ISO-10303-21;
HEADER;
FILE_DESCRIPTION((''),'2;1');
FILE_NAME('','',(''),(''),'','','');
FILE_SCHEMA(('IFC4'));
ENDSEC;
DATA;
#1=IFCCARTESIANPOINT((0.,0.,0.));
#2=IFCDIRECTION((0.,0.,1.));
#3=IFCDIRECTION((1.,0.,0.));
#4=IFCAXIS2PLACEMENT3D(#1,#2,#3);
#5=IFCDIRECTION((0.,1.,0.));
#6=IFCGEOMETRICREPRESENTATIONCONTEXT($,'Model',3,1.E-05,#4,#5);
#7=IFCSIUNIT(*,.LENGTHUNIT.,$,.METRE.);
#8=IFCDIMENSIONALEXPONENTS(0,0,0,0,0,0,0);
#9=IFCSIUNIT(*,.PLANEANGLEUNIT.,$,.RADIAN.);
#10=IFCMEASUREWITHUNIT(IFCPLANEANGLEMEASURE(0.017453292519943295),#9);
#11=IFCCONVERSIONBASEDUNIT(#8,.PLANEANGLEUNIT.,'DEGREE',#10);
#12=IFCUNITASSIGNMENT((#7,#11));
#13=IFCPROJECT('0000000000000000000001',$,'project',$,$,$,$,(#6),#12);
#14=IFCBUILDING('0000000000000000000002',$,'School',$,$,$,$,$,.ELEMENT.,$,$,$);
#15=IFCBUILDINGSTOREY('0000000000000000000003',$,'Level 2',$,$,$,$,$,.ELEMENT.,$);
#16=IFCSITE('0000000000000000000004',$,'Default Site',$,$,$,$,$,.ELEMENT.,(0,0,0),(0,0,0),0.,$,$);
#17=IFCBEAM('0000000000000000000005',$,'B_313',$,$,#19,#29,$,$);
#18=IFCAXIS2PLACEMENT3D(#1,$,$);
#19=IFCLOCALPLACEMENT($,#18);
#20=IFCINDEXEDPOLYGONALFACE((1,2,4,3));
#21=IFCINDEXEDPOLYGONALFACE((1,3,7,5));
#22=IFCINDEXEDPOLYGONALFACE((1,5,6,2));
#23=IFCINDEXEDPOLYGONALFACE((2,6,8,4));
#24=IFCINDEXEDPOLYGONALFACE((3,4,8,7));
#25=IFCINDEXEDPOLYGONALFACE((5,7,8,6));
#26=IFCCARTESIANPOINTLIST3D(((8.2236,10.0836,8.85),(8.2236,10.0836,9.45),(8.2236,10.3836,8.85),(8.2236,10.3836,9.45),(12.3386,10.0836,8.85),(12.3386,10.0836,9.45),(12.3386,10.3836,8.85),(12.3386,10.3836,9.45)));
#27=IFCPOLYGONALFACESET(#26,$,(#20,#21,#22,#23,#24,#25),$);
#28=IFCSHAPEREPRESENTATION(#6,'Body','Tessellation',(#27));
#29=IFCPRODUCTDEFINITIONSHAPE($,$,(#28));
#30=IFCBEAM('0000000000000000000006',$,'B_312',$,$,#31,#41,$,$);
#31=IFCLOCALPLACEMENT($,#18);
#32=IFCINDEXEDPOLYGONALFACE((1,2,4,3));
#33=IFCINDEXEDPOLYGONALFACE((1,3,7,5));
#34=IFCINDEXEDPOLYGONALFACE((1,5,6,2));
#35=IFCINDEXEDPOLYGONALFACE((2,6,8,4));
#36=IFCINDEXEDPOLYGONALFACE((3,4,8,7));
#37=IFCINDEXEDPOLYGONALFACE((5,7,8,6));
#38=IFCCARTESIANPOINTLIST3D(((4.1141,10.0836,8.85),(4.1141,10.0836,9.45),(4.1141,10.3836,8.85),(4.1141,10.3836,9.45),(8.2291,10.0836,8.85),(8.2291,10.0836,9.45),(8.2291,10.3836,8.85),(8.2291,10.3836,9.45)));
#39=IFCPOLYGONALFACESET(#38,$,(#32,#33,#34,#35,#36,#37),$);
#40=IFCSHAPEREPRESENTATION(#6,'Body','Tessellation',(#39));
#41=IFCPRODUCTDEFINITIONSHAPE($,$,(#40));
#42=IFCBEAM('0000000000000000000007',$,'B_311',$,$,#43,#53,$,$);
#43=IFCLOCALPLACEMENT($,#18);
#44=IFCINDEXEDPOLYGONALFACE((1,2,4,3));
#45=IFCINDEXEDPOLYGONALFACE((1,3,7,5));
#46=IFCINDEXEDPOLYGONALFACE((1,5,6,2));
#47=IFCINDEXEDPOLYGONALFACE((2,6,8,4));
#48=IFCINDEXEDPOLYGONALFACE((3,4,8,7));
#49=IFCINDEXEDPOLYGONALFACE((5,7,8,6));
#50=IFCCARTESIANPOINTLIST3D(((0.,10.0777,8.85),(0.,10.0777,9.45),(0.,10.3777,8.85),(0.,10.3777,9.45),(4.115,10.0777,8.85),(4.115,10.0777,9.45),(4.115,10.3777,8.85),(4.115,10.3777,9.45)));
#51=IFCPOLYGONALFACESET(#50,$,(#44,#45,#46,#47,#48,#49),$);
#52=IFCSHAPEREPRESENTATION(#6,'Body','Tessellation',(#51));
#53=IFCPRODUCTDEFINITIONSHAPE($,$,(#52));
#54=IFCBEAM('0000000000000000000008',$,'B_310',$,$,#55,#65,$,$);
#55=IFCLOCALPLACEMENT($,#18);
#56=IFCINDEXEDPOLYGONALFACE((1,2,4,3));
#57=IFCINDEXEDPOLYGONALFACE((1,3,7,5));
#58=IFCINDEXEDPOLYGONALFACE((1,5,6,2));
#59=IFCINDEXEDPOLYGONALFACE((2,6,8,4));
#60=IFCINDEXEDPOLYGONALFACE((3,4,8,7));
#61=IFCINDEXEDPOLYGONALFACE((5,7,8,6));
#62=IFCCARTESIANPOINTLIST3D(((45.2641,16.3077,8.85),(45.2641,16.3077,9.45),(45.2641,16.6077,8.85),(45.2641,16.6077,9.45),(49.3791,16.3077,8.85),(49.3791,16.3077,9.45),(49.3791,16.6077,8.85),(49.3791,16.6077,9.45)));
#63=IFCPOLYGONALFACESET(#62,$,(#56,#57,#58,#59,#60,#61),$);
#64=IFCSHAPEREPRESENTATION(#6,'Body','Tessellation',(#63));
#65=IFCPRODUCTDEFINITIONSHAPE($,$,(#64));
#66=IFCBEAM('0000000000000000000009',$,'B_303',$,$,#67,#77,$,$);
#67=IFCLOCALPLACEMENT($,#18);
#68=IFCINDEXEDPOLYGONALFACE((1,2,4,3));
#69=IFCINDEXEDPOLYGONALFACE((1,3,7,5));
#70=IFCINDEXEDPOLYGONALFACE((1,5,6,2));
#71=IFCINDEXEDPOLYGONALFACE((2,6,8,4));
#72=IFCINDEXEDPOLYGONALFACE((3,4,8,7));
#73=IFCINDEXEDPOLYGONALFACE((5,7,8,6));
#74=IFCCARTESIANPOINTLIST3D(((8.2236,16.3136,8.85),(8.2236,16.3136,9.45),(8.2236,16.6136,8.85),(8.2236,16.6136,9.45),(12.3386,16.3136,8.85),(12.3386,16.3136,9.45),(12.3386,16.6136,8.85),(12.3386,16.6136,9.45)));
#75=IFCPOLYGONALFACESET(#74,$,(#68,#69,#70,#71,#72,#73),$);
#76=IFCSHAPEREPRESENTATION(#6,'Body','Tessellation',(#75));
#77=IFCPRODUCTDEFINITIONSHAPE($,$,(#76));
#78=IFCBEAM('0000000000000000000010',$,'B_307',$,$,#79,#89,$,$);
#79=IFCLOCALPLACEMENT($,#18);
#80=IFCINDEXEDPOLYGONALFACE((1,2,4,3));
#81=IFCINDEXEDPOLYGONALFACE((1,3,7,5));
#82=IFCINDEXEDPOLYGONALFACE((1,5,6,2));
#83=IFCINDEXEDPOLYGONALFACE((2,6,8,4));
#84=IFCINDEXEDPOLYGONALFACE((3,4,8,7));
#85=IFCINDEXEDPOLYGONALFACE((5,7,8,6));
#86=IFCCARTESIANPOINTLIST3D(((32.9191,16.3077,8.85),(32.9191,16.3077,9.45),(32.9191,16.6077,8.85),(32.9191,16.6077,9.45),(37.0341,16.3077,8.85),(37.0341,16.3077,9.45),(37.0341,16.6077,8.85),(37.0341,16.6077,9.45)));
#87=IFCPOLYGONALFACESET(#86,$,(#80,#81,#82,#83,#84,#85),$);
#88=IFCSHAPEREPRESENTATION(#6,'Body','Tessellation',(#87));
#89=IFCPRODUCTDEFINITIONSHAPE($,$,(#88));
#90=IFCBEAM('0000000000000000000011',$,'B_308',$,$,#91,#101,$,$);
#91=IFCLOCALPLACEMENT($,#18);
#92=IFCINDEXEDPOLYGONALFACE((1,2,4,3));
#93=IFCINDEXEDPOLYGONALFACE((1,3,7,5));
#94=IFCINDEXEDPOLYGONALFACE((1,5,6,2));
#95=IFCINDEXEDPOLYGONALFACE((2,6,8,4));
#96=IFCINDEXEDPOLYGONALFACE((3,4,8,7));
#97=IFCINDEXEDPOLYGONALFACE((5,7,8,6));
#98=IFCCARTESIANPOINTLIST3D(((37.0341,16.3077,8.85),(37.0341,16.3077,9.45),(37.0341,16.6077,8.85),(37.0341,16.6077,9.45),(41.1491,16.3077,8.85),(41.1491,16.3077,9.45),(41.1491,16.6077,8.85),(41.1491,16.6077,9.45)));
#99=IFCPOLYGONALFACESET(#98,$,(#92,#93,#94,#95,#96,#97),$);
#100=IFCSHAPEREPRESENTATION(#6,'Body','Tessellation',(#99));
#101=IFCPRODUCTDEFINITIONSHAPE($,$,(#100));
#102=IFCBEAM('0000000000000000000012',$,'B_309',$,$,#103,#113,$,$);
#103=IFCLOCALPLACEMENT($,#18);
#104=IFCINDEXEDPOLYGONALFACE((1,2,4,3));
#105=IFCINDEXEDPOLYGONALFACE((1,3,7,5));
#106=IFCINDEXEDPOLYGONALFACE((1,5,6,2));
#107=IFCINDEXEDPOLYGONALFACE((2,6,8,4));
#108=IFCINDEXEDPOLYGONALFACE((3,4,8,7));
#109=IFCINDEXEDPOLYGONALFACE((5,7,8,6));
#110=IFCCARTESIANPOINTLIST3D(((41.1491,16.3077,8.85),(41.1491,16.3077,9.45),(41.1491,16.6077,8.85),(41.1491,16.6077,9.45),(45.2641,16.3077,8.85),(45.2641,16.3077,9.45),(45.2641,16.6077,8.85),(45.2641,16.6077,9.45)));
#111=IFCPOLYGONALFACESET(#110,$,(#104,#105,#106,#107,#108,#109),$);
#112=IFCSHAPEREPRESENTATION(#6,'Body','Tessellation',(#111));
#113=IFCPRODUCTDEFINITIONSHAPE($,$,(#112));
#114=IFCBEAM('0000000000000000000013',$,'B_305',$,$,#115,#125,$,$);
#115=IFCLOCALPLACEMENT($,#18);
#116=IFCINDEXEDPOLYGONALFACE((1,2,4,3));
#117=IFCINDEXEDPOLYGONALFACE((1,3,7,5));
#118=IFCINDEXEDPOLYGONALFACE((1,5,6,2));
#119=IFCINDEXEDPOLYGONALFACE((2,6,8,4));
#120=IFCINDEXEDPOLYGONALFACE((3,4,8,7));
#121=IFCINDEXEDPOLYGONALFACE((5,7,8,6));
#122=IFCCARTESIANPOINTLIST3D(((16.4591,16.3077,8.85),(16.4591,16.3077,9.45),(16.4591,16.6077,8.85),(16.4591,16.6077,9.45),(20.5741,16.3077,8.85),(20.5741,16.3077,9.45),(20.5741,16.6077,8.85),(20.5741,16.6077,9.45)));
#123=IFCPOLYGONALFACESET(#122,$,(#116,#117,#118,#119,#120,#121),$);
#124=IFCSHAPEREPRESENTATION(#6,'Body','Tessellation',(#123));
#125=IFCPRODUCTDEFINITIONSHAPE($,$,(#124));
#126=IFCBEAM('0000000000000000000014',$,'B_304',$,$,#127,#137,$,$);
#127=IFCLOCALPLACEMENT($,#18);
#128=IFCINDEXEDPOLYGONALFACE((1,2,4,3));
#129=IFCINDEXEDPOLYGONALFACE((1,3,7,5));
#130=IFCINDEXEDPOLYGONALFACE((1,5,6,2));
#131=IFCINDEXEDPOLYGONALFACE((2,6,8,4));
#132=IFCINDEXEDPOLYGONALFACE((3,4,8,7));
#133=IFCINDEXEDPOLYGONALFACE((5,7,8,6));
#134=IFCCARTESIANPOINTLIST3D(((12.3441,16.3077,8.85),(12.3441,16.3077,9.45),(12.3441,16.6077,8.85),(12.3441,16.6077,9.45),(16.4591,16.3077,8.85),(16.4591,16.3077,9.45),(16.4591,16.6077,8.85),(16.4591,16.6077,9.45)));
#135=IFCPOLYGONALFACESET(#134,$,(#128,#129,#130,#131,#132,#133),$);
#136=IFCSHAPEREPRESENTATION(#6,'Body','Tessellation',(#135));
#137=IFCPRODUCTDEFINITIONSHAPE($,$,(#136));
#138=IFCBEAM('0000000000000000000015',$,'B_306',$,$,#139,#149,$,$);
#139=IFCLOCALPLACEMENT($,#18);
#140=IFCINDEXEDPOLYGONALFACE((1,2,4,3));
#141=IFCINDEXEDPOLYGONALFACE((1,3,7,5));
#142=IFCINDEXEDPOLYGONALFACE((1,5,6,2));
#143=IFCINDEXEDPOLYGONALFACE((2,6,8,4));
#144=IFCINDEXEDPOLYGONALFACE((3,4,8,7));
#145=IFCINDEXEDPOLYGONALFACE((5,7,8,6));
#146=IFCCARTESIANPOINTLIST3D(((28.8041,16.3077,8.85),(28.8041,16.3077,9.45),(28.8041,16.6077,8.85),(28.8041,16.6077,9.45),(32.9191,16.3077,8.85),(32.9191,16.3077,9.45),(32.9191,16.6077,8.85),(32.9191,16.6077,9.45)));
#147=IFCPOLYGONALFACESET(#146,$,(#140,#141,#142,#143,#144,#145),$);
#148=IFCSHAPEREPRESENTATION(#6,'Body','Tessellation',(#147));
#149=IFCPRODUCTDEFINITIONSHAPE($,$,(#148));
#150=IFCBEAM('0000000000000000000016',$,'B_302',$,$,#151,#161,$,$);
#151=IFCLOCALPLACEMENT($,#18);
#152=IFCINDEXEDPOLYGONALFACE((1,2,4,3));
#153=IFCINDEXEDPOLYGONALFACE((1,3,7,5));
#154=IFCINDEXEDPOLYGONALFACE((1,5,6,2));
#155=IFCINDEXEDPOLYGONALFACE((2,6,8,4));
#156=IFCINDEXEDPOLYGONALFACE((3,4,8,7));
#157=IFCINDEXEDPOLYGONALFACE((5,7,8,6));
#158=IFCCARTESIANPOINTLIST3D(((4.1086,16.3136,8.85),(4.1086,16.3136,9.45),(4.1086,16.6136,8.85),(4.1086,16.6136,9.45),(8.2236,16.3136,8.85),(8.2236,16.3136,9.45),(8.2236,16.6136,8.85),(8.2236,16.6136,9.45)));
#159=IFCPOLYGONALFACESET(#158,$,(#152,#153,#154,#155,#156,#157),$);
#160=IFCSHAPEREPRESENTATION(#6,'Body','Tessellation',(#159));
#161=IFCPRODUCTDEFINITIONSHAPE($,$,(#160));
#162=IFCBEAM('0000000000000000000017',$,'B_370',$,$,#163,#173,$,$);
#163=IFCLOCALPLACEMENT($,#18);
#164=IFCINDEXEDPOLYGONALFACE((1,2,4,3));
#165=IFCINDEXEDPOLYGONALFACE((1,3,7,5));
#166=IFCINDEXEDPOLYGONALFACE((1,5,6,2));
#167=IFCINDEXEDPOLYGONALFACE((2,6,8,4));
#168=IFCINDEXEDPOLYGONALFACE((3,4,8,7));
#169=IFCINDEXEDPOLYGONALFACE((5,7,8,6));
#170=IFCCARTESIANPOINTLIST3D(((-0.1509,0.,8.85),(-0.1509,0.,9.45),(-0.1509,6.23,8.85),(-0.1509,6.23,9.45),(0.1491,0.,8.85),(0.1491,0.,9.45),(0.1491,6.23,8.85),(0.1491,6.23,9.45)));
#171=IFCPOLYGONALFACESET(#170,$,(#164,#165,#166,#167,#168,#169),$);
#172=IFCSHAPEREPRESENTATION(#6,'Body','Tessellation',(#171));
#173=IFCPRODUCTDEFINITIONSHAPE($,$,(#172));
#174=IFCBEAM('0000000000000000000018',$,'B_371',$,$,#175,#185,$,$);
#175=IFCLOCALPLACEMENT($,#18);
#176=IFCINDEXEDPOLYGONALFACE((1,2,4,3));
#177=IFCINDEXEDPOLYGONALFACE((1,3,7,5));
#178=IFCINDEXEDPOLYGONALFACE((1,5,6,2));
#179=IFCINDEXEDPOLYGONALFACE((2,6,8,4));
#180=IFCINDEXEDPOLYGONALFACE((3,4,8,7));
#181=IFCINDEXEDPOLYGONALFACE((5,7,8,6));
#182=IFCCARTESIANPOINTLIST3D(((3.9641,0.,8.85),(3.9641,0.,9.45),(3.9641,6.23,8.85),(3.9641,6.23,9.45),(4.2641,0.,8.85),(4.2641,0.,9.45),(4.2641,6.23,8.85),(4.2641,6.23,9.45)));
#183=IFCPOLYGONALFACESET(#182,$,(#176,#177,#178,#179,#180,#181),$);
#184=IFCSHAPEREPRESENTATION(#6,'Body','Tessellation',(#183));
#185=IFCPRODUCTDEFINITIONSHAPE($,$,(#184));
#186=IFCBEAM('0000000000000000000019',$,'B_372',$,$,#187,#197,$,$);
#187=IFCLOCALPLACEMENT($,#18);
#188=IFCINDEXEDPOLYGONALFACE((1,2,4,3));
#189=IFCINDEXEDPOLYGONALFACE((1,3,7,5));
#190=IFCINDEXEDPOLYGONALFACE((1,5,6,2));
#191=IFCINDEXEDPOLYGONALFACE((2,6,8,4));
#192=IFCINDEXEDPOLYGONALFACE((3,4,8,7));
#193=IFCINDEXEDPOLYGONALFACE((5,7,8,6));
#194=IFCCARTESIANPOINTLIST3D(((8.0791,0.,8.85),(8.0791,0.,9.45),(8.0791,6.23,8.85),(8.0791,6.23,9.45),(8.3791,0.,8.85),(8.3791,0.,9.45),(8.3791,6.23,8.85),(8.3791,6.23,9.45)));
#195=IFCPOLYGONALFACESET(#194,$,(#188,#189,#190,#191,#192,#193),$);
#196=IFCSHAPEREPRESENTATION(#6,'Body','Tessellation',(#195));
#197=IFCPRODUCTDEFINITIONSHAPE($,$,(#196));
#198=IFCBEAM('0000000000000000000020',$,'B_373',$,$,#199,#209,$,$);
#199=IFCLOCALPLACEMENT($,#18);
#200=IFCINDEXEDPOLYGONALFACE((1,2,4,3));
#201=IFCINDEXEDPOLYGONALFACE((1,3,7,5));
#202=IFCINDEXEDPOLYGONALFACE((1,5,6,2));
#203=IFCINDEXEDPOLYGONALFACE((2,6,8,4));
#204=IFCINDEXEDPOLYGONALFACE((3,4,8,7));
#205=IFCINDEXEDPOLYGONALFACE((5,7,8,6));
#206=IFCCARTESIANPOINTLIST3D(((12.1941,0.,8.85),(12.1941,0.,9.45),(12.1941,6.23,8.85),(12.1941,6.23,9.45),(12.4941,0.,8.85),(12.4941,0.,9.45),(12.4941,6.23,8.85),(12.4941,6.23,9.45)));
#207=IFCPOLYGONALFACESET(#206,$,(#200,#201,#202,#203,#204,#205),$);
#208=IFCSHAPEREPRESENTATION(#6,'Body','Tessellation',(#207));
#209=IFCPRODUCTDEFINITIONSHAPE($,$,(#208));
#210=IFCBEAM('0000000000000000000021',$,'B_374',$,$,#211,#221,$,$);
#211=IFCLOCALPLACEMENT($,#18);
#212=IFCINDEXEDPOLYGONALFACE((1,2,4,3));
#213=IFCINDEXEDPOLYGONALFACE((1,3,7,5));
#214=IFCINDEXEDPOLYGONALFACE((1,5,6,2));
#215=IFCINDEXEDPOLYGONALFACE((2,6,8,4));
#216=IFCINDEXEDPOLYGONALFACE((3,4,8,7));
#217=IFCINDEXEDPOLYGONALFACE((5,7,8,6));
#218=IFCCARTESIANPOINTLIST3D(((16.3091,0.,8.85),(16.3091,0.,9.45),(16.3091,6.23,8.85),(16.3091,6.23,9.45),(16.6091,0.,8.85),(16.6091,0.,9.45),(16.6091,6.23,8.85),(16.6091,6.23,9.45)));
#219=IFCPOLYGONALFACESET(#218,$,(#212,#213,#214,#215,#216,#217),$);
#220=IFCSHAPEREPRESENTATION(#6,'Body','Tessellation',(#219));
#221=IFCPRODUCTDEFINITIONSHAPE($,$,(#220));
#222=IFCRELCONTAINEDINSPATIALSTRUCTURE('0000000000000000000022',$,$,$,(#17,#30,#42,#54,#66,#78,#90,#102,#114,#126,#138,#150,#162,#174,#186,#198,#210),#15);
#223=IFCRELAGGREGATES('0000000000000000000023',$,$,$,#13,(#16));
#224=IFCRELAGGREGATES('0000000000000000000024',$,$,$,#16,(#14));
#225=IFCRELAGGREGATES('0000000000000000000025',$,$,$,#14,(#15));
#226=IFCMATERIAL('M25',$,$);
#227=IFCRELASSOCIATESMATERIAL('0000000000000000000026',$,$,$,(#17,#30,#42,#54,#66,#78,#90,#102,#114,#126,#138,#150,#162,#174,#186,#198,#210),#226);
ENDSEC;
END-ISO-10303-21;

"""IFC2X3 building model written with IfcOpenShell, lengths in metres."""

from ifc_helpers import new_model, entity, si_unit, converted_unit, direction, frame, frame_2d, origin_with_axes, place, context, project, spatial, rectangle, extrude, material, element, save


model = new_model("IFC2X3")

# Units and contexts
model_context = context("Model", 3, precision=1e-05, world=origin_with_axes(), true_north=direction((0.0, 1.0, 0.0)))
ifc_project = project(units=[si_unit("LENGTHUNIT", "METRE"), converted_unit("PLANEANGLEUNIT", "DEGREE", entity("IfcPlaneAngleMeasure", 0.017453292519943295), si_unit("PLANEANGLEUNIT", "RADIAN"), dimensions=[0, 0, 0, 0, 0, 0, 0])], contexts=[model_context])

# Site, building, storey
site = spatial("IfcSite", under=ifc_project, Name="Default Site", CompositionType="ELEMENT", RefLatitude=(0, 0, 0), RefLongitude=(0, 0, 0), RefElevation=0.0)
building = spatial("IfcBuilding", under=site, Name="School", CompositionType="ELEMENT")
storey = spatial("IfcBuildingStorey", under=building, Name="Level 2", CompositionType="ELEMENT")

# Beams
ifc_material = material(Name="M25")
placement = place(None, origin_with_axes())
element("IfcBeam", 1, at=placement, inside=storey, material=ifc_material, Name="B_313", context=model_context, shape_type="SweptSolid", body=[
    extrude(rectangle(XDim=0.3, YDim=0.6, at=frame_2d((0.0, 0.0), x_axis=(0.0, 1.0, 0.0))), frame((8.2236, 10.2336, 9.15), z_axis=(1.0, 0.0, 0.0), x_axis=(0.0, 0.0, -1.0)), (0.0, 0.0, 1.0), 4.115),
])
element("IfcBeam", 2, at=placement, inside=storey, material=ifc_material, Name="B_312", context=model_context, shape_type="SweptSolid", body=[
    extrude(rectangle(XDim=0.3, YDim=0.6, at=frame_2d((0.0, 0.0), x_axis=(0.0, 1.0, 0.0))), frame((4.1141, 10.2336, 9.15), z_axis=(1.0, 0.0, 0.0), x_axis=(0.0, 0.0, -1.0)), (0.0, 0.0, 1.0), 4.115),
])
element("IfcBeam", 3, at=placement, inside=storey, material=ifc_material, Name="B_311", context=model_context, shape_type="SweptSolid", body=[
    extrude(rectangle(XDim=0.3, YDim=0.6, at=frame_2d((0.0, 0.0), x_axis=(0.0, 1.0, 0.0))), frame((0.0, 10.2277, 9.15), z_axis=(1.0, 0.0, 0.0), x_axis=(0.0, 0.0, -1.0)), (0.0, 0.0, 1.0), 4.115),
])
element("IfcBeam", 4, at=placement, inside=storey, material=ifc_material, Name="B_310", context=model_context, shape_type="SweptSolid", body=[
    extrude(rectangle(XDim=0.3, YDim=0.6, at=frame_2d((0.0, 0.0), x_axis=(0.0, 1.0, 0.0))), frame((45.2641, 16.4577, 9.15), z_axis=(1.0, 0.0, 0.0), x_axis=(0.0, 0.0, -1.0)), (0.0, 0.0, 1.0), 4.115),
])
element("IfcBeam", 5, at=placement, inside=storey, material=ifc_material, Name="B_303", context=model_context, shape_type="SweptSolid", body=[
    extrude(rectangle(XDim=0.3, YDim=0.6, at=frame_2d((0.0, 0.0), x_axis=(0.0, 1.0, 0.0))), frame((8.2236, 16.4636, 9.15), z_axis=(1.0, 0.0, 0.0), x_axis=(0.0, 0.0, -1.0)), (0.0, 0.0, 1.0), 4.115),
])
element("IfcBeam", 6, at=placement, inside=storey, material=ifc_material, Name="B_307", context=model_context, shape_type="SweptSolid", body=[
    extrude(rectangle(XDim=0.3, YDim=0.6, at=frame_2d((0.0, 0.0), x_axis=(0.0, 1.0, 0.0))), frame((32.9191, 16.4577, 9.15), z_axis=(1.0, 0.0, 0.0), x_axis=(0.0, 0.0, -1.0)), (0.0, 0.0, 1.0), 4.115),
])
element("IfcBeam", 7, at=placement, inside=storey, material=ifc_material, Name="B_308", context=model_context, shape_type="SweptSolid", body=[
    extrude(rectangle(XDim=0.3, YDim=0.6, at=frame_2d((0.0, 0.0), x_axis=(0.0, 1.0, 0.0))), frame((37.0341, 16.4577, 9.15), z_axis=(1.0, 0.0, 0.0), x_axis=(0.0, 0.0, -1.0)), (0.0, 0.0, 1.0), 4.115),
])
element("IfcBeam", 8, at=placement, inside=storey, material=ifc_material, Name="B_309", context=model_context, shape_type="SweptSolid", body=[
    extrude(rectangle(XDim=0.3, YDim=0.6, at=frame_2d((0.0, 0.0), x_axis=(0.0, 1.0, 0.0))), frame((41.1491, 16.4577, 9.15), z_axis=(1.0, 0.0, 0.0), x_axis=(0.0, 0.0, -1.0)), (0.0, 0.0, 1.0), 4.115),
])
element("IfcBeam", 9, at=placement, inside=storey, material=ifc_material, Name="B_305", context=model_context, shape_type="SweptSolid", body=[
    extrude(rectangle(XDim=0.3, YDim=0.6, at=frame_2d((0.0, 0.0), x_axis=(0.0, 1.0, 0.0))), frame((16.4591, 16.4577, 9.15), z_axis=(1.0, 0.0, 0.0), x_axis=(0.0, 0.0, -1.0)), (0.0, 0.0, 1.0), 4.115),
])
element("IfcBeam", 10, at=placement, inside=storey, material=ifc_material, Name="B_304", context=model_context, shape_type="SweptSolid", body=[
    extrude(rectangle(XDim=0.3, YDim=0.6, at=frame_2d((0.0, 0.0), x_axis=(0.0, 1.0, 0.0))), frame((12.3441, 16.4577, 9.15), z_axis=(1.0, 0.0, 0.0), x_axis=(0.0, 0.0, -1.0)), (0.0, 0.0, 1.0), 4.115),
])
element("IfcBeam", 11, at=placement, inside=storey, material=ifc_material, Name="B_306", context=model_context, shape_type="SweptSolid", body=[
    extrude(rectangle(XDim=0.3, YDim=0.6, at=frame_2d((0.0, 0.0), x_axis=(0.0, 1.0, 0.0))), frame((28.8041, 16.4577, 9.15), z_axis=(1.0, 0.0, 0.0), x_axis=(0.0, 0.0, -1.0)), (0.0, 0.0, 1.0), 4.115),
])
element("IfcBeam", 12, at=placement, inside=storey, material=ifc_material, Name="B_302", context=model_context, shape_type="SweptSolid", body=[
    extrude(rectangle(XDim=0.3, YDim=0.6, at=frame_2d((0.0, 0.0), x_axis=(0.0, 1.0, 0.0))), frame((4.1086, 16.4636, 9.15), z_axis=(1.0, 0.0, 0.0), x_axis=(0.0, 0.0, -1.0)), (0.0, 0.0, 1.0), 4.115),
])
element("IfcBeam", 13, at=placement, inside=storey, material=ifc_material, Name="B_370", context=model_context, shape_type="SweptSolid", body=[
    extrude(rectangle(XDim=0.3, YDim=0.6, at=frame_2d((0.0, 0.0), x_axis=(0.0, 1.0, 0.0))), frame((-0.0009, 0.0, 9.15), z_axis=(0.0, 1.0, 0.0), x_axis=(0.0, 0.0, -1.0)), (0.0, 0.0, 1.0), 6.23),
])
element("IfcBeam", 14, at=placement, inside=storey, material=ifc_material, Name="B_371", context=model_context, shape_type="SweptSolid", body=[
    extrude(rectangle(XDim=0.3, YDim=0.6, at=frame_2d((0.0, 0.0), x_axis=(0.0, 1.0, 0.0))), frame((4.1141, 0.0, 9.15), z_axis=(0.0, 1.0, 0.0), x_axis=(0.0, 0.0, -1.0)), (0.0, 0.0, 1.0), 6.23),
])
element("IfcBeam", 15, at=placement, inside=storey, material=ifc_material, Name="B_372", context=model_context, shape_type="SweptSolid", body=[
    extrude(rectangle(XDim=0.3, YDim=0.6, at=frame_2d((0.0, 0.0), x_axis=(0.0, 1.0, 0.0))), frame((8.2291, 0.0, 9.15), z_axis=(0.0, 1.0, 0.0), x_axis=(0.0, 0.0, -1.0)), (0.0, 0.0, 1.0), 6.23),
])
element("IfcBeam", 16, at=placement, inside=storey, material=ifc_material, Name="B_373", context=model_context, shape_type="SweptSolid", body=[
    extrude(rectangle(XDim=0.3, YDim=0.6, at=frame_2d((0.0, 0.0), x_axis=(0.0, 1.0, 0.0))), frame((12.3441, 0.0, 9.15), z_axis=(0.0, 1.0, 0.0), x_axis=(0.0, 0.0, -1.0)), (0.0, 0.0, 1.0), 6.23),
])
element("IfcBeam", 17, at=placement, inside=storey, material=ifc_material, Name="B_374", context=model_context, shape_type="SweptSolid", body=[
    extrude(rectangle(XDim=0.3, YDim=0.6, at=frame_2d((0.0, 0.0), x_axis=(0.0, 1.0, 0.0))), frame((16.4591, 0.0, 9.15), z_axis=(0.0, 1.0, 0.0), x_axis=(0.0, 0.0, -1.0)), (0.0, 0.0, 1.0), 6.23),
])

save(model, "model.ifc")
